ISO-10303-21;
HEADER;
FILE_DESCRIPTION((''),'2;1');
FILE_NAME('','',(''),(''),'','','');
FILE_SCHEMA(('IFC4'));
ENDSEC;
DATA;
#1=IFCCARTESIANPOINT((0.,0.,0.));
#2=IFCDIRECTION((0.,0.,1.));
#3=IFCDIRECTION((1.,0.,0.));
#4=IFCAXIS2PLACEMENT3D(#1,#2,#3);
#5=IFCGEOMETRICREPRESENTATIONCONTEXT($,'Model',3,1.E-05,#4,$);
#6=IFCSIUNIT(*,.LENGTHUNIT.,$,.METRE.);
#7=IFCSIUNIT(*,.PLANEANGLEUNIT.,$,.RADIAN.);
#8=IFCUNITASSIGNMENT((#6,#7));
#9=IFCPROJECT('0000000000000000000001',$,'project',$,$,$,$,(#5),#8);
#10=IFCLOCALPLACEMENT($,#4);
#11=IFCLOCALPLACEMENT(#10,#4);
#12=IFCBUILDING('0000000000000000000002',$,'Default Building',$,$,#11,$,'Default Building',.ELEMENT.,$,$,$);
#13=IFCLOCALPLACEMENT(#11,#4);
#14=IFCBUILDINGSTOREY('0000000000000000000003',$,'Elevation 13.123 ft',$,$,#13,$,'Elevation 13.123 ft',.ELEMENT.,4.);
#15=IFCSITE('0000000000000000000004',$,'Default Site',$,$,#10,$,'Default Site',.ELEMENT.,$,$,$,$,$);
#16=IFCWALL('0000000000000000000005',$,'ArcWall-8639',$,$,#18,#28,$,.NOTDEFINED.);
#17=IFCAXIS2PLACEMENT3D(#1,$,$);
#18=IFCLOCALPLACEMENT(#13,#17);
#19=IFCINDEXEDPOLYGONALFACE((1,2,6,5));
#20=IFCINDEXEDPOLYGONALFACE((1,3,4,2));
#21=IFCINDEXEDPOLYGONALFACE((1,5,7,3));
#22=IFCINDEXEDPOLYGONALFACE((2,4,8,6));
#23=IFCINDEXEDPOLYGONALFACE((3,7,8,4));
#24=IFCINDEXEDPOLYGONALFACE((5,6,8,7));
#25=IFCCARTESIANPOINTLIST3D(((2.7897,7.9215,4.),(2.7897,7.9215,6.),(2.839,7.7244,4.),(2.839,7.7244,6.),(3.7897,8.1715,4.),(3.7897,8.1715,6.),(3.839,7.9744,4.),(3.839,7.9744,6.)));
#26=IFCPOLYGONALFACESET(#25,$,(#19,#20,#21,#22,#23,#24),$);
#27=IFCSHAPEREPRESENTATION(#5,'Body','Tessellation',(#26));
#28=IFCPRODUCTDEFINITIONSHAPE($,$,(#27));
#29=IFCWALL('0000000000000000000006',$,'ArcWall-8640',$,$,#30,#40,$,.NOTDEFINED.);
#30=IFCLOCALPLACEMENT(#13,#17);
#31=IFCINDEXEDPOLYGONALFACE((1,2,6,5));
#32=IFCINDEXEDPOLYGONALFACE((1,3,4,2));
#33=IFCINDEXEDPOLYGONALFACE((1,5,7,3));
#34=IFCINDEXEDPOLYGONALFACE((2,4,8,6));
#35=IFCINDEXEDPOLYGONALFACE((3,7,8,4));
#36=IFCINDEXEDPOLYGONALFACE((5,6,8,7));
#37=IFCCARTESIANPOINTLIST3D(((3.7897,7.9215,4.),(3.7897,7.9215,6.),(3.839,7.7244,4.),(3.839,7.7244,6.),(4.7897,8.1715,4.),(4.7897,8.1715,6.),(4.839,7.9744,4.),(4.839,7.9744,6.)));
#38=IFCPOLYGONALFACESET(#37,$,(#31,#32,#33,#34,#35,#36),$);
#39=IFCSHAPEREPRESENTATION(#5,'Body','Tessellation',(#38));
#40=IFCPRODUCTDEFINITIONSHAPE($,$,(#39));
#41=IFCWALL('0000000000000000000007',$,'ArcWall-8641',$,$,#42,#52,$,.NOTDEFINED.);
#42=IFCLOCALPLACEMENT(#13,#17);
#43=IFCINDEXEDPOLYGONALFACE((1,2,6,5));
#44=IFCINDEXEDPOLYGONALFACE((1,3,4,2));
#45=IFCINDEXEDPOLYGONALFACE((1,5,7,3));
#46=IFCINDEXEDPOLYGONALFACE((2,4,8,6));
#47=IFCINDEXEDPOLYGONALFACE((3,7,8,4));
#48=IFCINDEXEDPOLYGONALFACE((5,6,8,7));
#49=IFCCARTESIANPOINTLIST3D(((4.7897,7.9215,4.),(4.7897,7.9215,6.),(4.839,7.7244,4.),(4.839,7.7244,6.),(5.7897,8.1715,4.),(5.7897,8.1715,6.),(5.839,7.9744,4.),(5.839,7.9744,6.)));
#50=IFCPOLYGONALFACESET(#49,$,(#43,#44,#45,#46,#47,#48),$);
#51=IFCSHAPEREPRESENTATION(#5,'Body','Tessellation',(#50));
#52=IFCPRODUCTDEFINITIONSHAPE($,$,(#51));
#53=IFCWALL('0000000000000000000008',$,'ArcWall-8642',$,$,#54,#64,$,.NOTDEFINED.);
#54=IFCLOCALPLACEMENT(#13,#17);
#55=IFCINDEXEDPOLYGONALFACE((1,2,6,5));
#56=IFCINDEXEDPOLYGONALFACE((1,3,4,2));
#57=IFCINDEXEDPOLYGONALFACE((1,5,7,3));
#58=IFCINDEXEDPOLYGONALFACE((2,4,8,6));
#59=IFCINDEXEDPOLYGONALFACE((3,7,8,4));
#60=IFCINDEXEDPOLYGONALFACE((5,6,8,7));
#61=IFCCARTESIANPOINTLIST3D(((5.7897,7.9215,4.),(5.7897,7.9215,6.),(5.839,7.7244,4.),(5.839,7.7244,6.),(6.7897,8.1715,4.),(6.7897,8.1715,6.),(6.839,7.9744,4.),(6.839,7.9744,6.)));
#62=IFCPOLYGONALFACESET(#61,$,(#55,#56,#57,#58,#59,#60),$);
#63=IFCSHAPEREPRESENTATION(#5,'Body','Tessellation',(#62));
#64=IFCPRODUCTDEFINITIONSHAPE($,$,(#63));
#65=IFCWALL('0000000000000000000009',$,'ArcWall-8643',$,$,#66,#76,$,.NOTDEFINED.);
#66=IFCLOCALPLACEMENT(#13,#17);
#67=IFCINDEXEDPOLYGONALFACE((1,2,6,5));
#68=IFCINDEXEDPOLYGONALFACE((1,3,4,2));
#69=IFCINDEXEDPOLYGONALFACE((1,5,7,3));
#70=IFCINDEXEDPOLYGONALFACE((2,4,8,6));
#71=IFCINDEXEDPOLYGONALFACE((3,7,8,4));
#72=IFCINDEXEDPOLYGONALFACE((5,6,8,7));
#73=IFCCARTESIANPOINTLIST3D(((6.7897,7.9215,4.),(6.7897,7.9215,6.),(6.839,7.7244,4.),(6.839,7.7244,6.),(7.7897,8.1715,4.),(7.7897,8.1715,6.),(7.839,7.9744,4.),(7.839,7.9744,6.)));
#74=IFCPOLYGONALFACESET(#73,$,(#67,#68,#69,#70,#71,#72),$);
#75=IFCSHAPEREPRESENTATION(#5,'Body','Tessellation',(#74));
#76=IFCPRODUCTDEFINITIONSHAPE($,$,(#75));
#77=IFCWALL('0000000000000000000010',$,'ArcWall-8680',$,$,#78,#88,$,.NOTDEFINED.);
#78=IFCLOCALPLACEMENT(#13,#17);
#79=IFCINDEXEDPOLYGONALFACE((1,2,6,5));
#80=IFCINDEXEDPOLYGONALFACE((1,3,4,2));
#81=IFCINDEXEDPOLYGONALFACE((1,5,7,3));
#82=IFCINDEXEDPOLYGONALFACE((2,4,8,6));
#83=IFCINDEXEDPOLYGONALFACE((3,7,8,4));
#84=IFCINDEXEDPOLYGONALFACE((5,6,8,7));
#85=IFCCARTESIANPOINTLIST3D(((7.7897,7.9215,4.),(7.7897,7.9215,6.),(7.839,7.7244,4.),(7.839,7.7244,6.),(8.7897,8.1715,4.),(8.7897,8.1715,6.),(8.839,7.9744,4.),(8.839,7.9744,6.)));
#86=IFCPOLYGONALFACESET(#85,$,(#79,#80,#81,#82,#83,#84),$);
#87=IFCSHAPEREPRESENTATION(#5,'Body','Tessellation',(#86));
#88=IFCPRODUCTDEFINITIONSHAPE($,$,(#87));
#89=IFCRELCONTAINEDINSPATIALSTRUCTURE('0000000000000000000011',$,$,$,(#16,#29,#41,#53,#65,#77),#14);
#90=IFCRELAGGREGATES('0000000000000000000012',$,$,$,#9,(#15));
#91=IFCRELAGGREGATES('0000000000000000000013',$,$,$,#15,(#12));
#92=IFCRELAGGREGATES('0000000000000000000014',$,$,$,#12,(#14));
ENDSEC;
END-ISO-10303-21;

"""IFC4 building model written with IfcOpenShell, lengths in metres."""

from ifc_helpers import new_model, si_unit, frame, origin_with_axes, origin_2d_with_axis, place, context, project, spatial, rectangle, extrude, element, save


model = new_model("IFC4")

# Units and contexts
model_context = context("Model", 3, precision=1e-05, world=origin_with_axes())
ifc_project = project(units=[si_unit("LENGTHUNIT", "METRE"), si_unit("PLANEANGLEUNIT", "RADIAN")], contexts=[model_context])

# Site, building, storey
site_placement = place(None, origin_with_axes())
site = spatial("IfcSite", under=ifc_project, at=site_placement, Name="Default Site", LongName="Default Site", CompositionType="ELEMENT")
building_placement = place(site_placement, origin_with_axes())
building = spatial("IfcBuilding", under=site, at=building_placement, Name="Default Building", LongName="Default Building", CompositionType="ELEMENT")
storey_placement = place(building_placement, origin_with_axes())
storey = spatial("IfcBuildingStorey", under=building, at=storey_placement, Name="Elevation 13.123 ft", LongName="Elevation 13.123 ft", CompositionType="ELEMENT", Elevation=4.0)

# Walls
for number, where, z_axis, x_axis, name in (
    (1, (3.3144, 7.948, 4.0), (0.0, 0.0, 1.0), (0.970143, 0.242536, 0.0), "ArcWall-8639"),
    (2, (4.3144, 7.948, 4.0), (0.0, 0.0, 1.0), (0.970143, 0.242536, 0.0), "ArcWall-8640"),
    (3, (5.3144, 7.948, 4.0), (0.0, 0.0, 1.0), (0.970143, 0.242536, 0.0), "ArcWall-8641"),
    (4, (6.3144, 7.948, 4.0), (0.0, 0.0, 1.0), (0.970143, 0.242536, 0.0), "ArcWall-8642"),
    (5, (7.3144, 7.948, 4.0), (0.0, 0.0, 1.0), (0.970143, 0.242536, 0.0), "ArcWall-8643"),
    (6, (8.3144, 7.948, 4.0), (0.0, 0.0, 1.0), (0.970143, 0.242536, 0.0), "ArcWall-8680"),
):
    element("IfcWall", number, at=place(storey_placement, frame(where, z_axis=z_axis, x_axis=x_axis)), inside=storey, Name=name, PredefinedType="NOTDEFINED", context=model_context, shape_type="SweptSolid", body=[
        extrude(rectangle(XDim=1.0308, YDim=0.2032, at=origin_2d_with_axis()), origin_with_axes(), (0.0, 0.0, 1.0), 2.0),
    ])

save(model, "model.ifc")
